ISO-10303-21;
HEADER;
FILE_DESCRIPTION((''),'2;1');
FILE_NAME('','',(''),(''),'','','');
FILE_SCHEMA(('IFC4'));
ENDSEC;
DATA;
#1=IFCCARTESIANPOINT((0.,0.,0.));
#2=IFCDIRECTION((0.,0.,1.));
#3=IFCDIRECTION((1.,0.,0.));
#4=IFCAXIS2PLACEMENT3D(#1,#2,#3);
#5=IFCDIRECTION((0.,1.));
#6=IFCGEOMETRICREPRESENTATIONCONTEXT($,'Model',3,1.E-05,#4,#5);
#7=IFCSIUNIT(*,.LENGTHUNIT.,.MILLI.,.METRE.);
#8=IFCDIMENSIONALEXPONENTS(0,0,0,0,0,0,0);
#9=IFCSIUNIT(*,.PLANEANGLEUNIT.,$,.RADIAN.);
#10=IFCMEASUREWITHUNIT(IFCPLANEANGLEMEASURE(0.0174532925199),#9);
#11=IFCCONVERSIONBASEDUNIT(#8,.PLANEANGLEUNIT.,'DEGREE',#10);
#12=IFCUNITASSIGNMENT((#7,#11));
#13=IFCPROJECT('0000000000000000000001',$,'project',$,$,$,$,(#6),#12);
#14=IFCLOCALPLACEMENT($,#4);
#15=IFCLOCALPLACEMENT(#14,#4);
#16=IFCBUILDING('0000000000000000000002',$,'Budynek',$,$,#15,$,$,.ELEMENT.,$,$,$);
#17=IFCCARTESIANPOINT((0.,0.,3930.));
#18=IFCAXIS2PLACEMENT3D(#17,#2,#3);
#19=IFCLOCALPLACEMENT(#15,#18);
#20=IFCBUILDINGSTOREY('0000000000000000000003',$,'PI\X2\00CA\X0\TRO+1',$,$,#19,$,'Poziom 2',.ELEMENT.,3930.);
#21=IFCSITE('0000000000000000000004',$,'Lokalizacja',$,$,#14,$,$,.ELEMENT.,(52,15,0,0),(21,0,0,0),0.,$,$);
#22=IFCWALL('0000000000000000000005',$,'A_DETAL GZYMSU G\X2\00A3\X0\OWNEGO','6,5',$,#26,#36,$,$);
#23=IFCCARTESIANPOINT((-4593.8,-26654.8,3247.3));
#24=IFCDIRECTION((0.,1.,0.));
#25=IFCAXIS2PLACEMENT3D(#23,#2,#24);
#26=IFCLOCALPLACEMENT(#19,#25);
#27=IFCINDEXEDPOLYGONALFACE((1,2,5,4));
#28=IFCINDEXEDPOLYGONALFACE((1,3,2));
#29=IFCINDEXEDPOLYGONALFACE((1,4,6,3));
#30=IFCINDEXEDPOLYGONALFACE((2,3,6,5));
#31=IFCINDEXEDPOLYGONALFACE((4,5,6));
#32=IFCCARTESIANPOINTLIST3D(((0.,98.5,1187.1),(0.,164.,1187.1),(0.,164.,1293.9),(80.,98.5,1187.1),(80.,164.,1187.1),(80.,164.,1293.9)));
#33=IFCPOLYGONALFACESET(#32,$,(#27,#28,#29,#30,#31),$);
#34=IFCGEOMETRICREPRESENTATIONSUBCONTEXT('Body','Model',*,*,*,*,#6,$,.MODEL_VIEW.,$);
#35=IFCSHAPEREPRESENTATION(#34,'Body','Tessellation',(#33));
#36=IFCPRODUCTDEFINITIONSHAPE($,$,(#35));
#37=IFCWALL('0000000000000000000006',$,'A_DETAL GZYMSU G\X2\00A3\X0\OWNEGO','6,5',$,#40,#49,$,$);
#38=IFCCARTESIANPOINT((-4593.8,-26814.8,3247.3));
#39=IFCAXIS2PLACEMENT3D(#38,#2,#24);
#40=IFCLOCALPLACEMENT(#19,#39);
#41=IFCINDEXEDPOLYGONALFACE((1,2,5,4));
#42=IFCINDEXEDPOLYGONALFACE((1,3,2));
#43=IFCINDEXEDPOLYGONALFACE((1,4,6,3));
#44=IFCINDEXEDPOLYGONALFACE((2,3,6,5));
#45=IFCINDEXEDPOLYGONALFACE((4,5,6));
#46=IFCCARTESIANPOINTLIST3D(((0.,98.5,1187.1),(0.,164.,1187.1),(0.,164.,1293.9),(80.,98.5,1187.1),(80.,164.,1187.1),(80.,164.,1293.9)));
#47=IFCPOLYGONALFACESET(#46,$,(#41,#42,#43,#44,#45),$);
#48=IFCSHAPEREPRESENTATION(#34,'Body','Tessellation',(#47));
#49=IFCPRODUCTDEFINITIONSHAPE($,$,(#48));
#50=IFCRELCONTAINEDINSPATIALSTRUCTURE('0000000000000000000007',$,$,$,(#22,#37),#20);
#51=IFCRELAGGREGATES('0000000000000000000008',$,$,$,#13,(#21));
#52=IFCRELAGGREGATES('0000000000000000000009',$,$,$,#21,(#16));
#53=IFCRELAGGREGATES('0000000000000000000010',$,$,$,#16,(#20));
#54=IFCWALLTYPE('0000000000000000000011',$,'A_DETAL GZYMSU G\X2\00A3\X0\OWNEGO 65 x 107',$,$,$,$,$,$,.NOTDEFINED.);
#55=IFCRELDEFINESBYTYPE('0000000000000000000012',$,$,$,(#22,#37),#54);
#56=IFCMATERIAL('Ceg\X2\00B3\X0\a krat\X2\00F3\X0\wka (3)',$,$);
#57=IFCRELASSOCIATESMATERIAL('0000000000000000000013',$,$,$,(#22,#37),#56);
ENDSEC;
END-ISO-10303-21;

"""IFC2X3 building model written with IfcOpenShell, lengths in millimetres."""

from ifc_helpers import new_model, entity, si_unit, converted_unit, direction, frame, origin_with_axes, place, context, subcontext, project, spatial, polyline, outline, extrude, material, type_object, element, save


model = new_model("IFC2X3")

# Units and contexts
model_context = context("Model", 3, precision=1e-05, world=origin_with_axes(), true_north=direction((0.0, 1.0)))
body_context = subcontext(model_context, "Body", "Model", "MODEL_VIEW")
ifc_project = project(units=[si_unit("LENGTHUNIT", "METRE", prefix="MILLI"), converted_unit("PLANEANGLEUNIT", "DEGREE", entity("IfcPlaneAngleMeasure", 0.0174532925199), si_unit("PLANEANGLEUNIT", "RADIAN"), dimensions=[0, 0, 0, 0, 0, 0, 0])], contexts=[model_context])

# Site, building, storey
site_placement = place(None, origin_with_axes())
site = spatial("IfcSite", under=ifc_project, at=site_placement, Name="Lokalizacja", CompositionType="ELEMENT", RefLatitude=(52, 15, 0, 0), RefLongitude=(21, 0, 0, 0), RefElevation=0.0)
building_placement = place(site_placement, origin_with_axes())
building = spatial("IfcBuilding", under=site, at=building_placement, Name="Budynek", CompositionType="ELEMENT")
storey_placement = place(building_placement, frame((0.0, 0.0, 3930.0), z_axis=(0.0, 0.0, 1.0), x_axis=(1.0, 0.0, 0.0)))
storey = spatial("IfcBuildingStorey", under=building, at=storey_placement, Name="PIÊTRO+1", LongName="Poziom 2", CompositionType="ELEMENT", Elevation=3930.0)

# Walls
ifc_material = material(Name="Ceg³a kratówka (3)")
wall_type_1 = type_object("IfcWallType", Name="A_DETAL GZYMSU G£OWNEGO 65 x 107", PredefinedType="NOTDEFINED")
for number, where, z_axis, x_axis, name in (
    (1, (-4593.8, -26654.8, 3247.3), (0.0, 0.0, 1.0), (0.0, 1.0, 0.0), "A_DETAL GZYMSU G£OWNEGO"),
    (2, (-4593.8, -26814.8, 3247.3), (0.0, 0.0, 1.0), (0.0, 1.0, 0.0), "A_DETAL GZYMSU G£OWNEGO"),
):
    element("IfcWall", number, at=place(storey_placement, frame(where, z_axis=z_axis, x_axis=x_axis)), inside=storey, type_object=wall_type_1, material=ifc_material, Name=name, Description="6,5", context=body_context, shape_type="SweptSolid", body=[
        extrude(outline(polyline([(-164.0, 1293.9), (-164.0, 1187.1), (-98.5, 1187.1), (-164.0, 1293.9)])), frame((0.0, 0.0, 0.0), z_axis=(-1.0, 0.0, 0.0), x_axis=(0.0, -1.0, 0.0)), (0.0, 0.0, -1.0), 80.0),
    ])

save(model, "model.ifc")
